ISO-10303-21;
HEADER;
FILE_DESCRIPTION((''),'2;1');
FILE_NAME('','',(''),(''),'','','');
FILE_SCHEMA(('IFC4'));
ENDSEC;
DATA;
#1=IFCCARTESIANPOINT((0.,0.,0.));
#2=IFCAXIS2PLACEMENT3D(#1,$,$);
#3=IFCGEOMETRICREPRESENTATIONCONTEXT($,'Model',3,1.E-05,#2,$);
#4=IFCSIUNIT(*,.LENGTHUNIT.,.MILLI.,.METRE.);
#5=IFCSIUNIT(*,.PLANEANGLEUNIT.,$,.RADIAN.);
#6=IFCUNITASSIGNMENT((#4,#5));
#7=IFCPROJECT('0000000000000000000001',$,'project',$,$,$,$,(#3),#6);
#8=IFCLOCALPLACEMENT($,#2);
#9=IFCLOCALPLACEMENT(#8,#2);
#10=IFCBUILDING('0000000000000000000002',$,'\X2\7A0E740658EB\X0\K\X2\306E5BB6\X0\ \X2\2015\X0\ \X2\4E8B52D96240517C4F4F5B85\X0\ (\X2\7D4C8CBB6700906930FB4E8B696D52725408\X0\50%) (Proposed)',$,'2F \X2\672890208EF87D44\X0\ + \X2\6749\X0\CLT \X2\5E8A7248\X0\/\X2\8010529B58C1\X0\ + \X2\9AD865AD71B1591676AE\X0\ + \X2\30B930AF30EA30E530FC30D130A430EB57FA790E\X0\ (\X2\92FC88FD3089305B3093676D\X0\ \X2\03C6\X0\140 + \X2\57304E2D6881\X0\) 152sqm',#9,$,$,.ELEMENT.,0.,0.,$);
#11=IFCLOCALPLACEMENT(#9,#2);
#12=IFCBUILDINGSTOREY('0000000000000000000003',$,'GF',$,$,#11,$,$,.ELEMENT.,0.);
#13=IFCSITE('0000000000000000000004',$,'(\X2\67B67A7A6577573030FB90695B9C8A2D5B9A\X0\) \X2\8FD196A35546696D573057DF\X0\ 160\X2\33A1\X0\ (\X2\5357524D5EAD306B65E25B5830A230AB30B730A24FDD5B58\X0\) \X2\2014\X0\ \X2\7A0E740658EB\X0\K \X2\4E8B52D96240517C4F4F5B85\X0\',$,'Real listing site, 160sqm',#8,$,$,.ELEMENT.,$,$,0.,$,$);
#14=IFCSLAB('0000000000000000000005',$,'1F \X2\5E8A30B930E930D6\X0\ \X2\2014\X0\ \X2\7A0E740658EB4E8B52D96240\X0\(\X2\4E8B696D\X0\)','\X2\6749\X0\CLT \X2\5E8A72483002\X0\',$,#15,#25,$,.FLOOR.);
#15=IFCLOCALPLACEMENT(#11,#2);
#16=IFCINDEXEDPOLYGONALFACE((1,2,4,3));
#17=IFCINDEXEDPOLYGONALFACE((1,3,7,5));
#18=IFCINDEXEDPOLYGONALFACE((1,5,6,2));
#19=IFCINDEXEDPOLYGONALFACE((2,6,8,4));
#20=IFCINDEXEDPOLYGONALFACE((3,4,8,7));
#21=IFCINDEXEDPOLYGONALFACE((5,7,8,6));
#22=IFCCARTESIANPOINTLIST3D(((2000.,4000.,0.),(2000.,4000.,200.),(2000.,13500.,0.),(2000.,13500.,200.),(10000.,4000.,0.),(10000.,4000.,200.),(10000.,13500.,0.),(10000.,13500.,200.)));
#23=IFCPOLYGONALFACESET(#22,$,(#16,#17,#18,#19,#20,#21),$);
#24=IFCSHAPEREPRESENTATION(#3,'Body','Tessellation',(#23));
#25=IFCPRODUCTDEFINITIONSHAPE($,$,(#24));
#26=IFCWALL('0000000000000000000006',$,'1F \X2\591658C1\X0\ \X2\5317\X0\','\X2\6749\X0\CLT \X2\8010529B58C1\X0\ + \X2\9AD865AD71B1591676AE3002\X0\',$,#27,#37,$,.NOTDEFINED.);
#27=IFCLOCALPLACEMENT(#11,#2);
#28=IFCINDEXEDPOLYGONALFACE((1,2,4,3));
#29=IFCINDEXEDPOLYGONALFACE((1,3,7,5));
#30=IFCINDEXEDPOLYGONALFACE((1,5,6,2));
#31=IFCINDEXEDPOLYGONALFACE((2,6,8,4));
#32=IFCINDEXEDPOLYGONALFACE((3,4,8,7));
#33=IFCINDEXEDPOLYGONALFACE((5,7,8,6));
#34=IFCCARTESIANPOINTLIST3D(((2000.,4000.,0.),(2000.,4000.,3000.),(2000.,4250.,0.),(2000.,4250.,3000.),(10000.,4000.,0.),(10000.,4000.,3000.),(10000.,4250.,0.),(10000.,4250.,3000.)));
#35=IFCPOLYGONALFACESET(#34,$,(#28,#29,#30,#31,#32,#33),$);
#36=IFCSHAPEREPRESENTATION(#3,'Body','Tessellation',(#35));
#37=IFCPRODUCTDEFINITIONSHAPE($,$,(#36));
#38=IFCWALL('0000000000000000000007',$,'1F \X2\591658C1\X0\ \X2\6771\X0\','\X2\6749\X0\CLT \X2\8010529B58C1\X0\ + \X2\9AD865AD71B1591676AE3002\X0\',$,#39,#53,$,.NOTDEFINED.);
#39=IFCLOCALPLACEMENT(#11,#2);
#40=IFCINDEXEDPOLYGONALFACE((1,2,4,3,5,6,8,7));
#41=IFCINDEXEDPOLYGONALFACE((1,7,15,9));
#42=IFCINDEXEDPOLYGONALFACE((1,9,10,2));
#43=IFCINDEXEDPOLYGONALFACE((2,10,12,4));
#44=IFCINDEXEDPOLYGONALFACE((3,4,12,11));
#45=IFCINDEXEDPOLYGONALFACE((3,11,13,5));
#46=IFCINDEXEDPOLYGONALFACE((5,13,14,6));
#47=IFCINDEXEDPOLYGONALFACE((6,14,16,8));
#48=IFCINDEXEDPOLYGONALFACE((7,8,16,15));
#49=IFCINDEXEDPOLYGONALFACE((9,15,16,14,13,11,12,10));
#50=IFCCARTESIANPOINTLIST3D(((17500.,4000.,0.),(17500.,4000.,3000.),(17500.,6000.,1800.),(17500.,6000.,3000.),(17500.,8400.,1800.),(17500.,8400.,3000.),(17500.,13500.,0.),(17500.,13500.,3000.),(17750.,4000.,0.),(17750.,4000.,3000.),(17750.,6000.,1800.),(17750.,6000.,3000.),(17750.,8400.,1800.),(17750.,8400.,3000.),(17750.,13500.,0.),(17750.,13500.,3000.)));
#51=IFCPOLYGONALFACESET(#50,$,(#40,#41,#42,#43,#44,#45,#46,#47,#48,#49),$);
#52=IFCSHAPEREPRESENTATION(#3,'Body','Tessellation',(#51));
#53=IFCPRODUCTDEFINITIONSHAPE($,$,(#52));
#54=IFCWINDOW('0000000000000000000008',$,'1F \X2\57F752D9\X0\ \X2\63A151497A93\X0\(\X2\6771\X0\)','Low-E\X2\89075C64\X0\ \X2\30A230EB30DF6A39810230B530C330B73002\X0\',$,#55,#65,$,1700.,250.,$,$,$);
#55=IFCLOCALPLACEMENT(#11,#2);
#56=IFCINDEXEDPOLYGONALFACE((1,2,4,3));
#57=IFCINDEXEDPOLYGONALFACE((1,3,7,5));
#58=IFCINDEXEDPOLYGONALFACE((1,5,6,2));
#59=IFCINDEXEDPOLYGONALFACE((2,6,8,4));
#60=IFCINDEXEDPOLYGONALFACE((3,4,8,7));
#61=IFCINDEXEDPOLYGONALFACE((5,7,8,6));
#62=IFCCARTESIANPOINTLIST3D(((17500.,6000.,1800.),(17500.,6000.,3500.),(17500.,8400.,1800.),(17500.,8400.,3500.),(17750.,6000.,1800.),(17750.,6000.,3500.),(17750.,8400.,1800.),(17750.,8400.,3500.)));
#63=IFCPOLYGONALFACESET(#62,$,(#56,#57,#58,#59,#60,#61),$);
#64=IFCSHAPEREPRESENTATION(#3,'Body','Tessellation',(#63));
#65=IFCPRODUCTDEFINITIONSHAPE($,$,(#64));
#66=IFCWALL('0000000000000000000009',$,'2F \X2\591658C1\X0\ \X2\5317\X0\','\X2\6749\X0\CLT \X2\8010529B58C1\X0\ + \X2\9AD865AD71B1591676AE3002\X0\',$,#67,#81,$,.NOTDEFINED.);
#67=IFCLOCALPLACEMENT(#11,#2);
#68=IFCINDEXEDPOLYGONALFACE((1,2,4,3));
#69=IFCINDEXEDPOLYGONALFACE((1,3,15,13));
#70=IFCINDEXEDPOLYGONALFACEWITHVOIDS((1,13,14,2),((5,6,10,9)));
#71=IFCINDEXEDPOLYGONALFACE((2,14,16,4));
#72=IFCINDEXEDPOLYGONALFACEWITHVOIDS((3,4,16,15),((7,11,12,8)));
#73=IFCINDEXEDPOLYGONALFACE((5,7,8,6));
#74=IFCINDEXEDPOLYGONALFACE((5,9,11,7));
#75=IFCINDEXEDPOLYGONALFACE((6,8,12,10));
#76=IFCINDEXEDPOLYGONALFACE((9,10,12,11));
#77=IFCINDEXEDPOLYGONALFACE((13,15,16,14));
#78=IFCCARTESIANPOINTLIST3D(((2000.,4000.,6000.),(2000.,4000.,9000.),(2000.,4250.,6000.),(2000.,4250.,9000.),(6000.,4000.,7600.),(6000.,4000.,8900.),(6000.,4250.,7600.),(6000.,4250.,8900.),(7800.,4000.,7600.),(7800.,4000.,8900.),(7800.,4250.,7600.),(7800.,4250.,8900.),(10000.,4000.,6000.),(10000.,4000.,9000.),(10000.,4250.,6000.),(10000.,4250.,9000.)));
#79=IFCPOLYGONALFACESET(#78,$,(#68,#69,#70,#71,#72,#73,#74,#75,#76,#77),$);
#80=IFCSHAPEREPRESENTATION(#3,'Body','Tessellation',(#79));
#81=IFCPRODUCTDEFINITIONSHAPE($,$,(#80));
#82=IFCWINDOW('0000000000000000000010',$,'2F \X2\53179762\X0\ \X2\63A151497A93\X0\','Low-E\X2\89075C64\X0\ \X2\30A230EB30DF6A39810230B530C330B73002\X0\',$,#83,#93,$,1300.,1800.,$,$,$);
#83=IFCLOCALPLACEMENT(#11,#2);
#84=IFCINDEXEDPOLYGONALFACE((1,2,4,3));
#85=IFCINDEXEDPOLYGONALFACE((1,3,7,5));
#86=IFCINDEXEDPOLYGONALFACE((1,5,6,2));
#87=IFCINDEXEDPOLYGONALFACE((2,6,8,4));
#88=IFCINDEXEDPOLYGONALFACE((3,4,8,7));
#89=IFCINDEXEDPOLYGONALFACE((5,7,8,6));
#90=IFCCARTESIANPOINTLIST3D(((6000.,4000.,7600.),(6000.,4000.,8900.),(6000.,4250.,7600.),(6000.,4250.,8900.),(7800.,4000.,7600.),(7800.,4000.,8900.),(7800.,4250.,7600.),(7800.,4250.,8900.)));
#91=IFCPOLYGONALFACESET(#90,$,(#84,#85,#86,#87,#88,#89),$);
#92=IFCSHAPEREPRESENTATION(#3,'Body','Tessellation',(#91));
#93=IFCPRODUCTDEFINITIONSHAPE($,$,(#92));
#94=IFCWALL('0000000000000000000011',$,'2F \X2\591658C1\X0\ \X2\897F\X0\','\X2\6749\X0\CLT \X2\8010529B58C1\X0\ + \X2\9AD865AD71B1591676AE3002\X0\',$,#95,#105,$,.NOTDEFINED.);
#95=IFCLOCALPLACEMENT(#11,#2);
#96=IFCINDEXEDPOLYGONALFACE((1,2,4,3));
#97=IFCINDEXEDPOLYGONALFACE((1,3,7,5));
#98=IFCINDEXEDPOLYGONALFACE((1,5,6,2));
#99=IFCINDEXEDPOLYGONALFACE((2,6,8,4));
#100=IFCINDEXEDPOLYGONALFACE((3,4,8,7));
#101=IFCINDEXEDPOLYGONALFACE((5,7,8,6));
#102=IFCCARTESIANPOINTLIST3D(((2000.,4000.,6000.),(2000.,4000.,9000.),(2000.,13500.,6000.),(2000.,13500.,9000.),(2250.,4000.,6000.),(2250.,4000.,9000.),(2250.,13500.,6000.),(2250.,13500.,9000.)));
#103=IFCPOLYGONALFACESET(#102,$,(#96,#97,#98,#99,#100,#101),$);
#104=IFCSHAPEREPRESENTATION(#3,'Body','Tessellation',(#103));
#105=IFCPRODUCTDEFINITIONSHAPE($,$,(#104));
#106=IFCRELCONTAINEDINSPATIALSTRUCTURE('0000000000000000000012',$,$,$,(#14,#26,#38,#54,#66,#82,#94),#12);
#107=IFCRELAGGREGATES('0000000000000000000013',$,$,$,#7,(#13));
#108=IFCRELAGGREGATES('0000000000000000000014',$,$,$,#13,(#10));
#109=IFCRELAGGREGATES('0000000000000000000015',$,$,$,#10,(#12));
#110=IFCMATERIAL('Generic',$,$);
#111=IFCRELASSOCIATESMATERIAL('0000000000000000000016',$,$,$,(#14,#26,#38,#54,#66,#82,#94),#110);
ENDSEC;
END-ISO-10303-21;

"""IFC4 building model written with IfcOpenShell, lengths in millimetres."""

from ifc_helpers import new_model, si_unit, frame, frame_2d, origin, place, context, project, spatial, rectangle, extrude, material, element, fill, save


model = new_model("IFC4")

# Units and contexts
model_context = context("Model", 3, precision=1e-05, world=origin())
ifc_project = project(units=[si_unit("LENGTHUNIT", "METRE", prefix="MILLI"), si_unit("PLANEANGLEUNIT", "RADIAN")], contexts=[model_context])

# Site, building, storey
site_placement = place(None, origin())
site = spatial("IfcSite", under=ifc_project, at=site_placement, Name="(架空敷地・適宜設定) 近隣商業地域 160㎡ (南前庭に既存アカシア保存) — 税理士K 事務所兼住宅", ObjectType="Real listing site, 160sqm", CompositionType="ELEMENT", RefElevation=0.0)
building_placement = place(site_placement, origin())
building = spatial("IfcBuilding", under=site, at=building_placement, Name="税理士Kの家 ― 事務所兼住宅 (経費最適・事業割合50%) (Proposed)", ObjectType="2F 木造軸組 + 杉CLT 床版/耐力壁 + 高断熱外皮 + スクリューパイル基礎 (鋼製らせん杭 φ140 + 地中梁) 152sqm", CompositionType="ELEMENT", ElevationOfRefHeight=0.0, ElevationOfTerrain=0.0)
storey_placement = place(building_placement, origin())
storey = spatial("IfcBuildingStorey", under=building, at=storey_placement, Name="GF", CompositionType="ELEMENT", Elevation=0.0)

# Shared definitions
ifc_material = material(Name="Generic")

# Slab
slab_1_placement = place(storey_placement, frame((1000.0, 2000.0, 0.0)))
element("IfcSlab", 1, at=slab_1_placement, inside=storey, material=ifc_material, Name="1F 床スラブ — 税理士事務所(事業)", Description="杉CLT 床版。", PredefinedType="FLOOR", context=model_context, shape_type="SweptSolid", body=[
    extrude(rectangle(XDim=8000.0, YDim=9500.0, at=frame_2d((4000.0, 4750.0))), frame((1000.0, 2000.0, 0.0)), (0.0, 0.0, 1.0), 200.0),
])

# Wall
wall_1_placement = place(storey_placement, frame((1000.0, 2000.0, 0.0)))
element("IfcWall", 2, at=wall_1_placement, inside=storey, material=ifc_material, Name="1F 外壁 北", Description="杉CLT 耐力壁 + 高断熱外皮。", PredefinedType="NOTDEFINED", context=model_context, shape_type="SweptSolid", body=[
    extrude(rectangle(XDim=8000.0, YDim=250.0, at=frame_2d((4000.0, 125.0))), frame((1000.0, 2000.0, 0.0)), (0.0, 0.0, 1.0), 3000.0),
])

# Wall, opening, window
wall_2_placement = place(storey_placement, frame((8750.0, 2000.0, 0.0)))
wall_2 = element("IfcWall", 3, at=wall_2_placement, inside=storey, material=ifc_material, Name="1F 外壁 東", Description="杉CLT 耐力壁 + 高断熱外皮。", PredefinedType="NOTDEFINED", context=model_context, shape_type="SweptSolid", body=[
    extrude(rectangle(XDim=250.0, YDim=9500.0, at=frame_2d((125.0, 4750.0))), frame((8750.0, 2000.0, 0.0)), (0.0, 0.0, 1.0), 3000.0),
])
opening_1_placement = place(storey_placement, frame((8750.0, 3000.0, 900.0)))
opening_1 = element("IfcOpeningElement", 4, at=opening_1_placement, cuts=wall_2, PredefinedType="NOTDEFINED", context=model_context, shape_type="SweptSolid", body=[
    extrude(rectangle(XDim=250.0, YDim=2400.0, at=frame_2d((125.0, 1200.0))), frame((8750.0, 3000.0, 900.0)), (0.0, 0.0, 1.0), 1700.0),
])
window_1_placement = place(storey_placement, frame((8750.0, 3000.0, 900.0)))
window_1 = element("IfcWindow", 5, at=window_1_placement, inside=storey, material=ifc_material, Name="1F 執務 採光窓(東)", Description="Low-E複層 アルミ樹脂サッシ。", OverallHeight=1700.0, OverallWidth=250.0, context=model_context, shape_type="SweptSolid", body=[
    extrude(rectangle(XDim=250.0, YDim=2400.0, at=frame_2d((125.0, 1200.0))), frame((8750.0, 3000.0, 900.0)), (0.0, 0.0, 1.0), 1700.0),
])
fill(opening_1, window_1)

# Wall, opening, window
wall_3_placement = place(storey_placement, frame((1000.0, 2000.0, 3000.0)))
wall_3 = element("IfcWall", 6, at=wall_3_placement, inside=storey, material=ifc_material, Name="2F 外壁 北", Description="杉CLT 耐力壁 + 高断熱外皮。", PredefinedType="NOTDEFINED", context=model_context, shape_type="SweptSolid", body=[
    extrude(rectangle(XDim=8000.0, YDim=250.0, at=frame_2d((4000.0, 125.0))), frame((1000.0, 2000.0, 3000.0)), (0.0, 0.0, 1.0), 3000.0),
])
opening_2_placement = place(storey_placement, frame((3000.0, 2000.0, 3800.0)))
opening_2 = element("IfcOpeningElement", 7, at=opening_2_placement, cuts=wall_3, PredefinedType="NOTDEFINED", context=model_context, shape_type="SweptSolid", body=[
    extrude(rectangle(XDim=1800.0, YDim=250.0, at=frame_2d((900.0, 125.0))), frame((3000.0, 2000.0, 3800.0)), (0.0, 0.0, 1.0), 1300.0),
])
window_2_placement = place(storey_placement, frame((3000.0, 2000.0, 3800.0)))
window_2 = element("IfcWindow", 8, at=window_2_placement, inside=storey, material=ifc_material, Name="2F 北面 採光窓", Description="Low-E複層 アルミ樹脂サッシ。", OverallHeight=1300.0, OverallWidth=1800.0, context=model_context, shape_type="SweptSolid", body=[
    extrude(rectangle(XDim=1800.0, YDim=250.0, at=frame_2d((900.0, 125.0))), frame((3000.0, 2000.0, 3800.0)), (0.0, 0.0, 1.0), 1300.0),
])
fill(opening_2, window_2)

# Wall
wall_4_placement = place(storey_placement, frame((1000.0, 2000.0, 3000.0)))
element("IfcWall", 9, at=wall_4_placement, inside=storey, material=ifc_material, Name="2F 外壁 西", Description="杉CLT 耐力壁 + 高断熱外皮。", PredefinedType="NOTDEFINED", context=model_context, shape_type="SweptSolid", body=[
    extrude(rectangle(XDim=250.0, YDim=9500.0, at=frame_2d((125.0, 4750.0))), frame((1000.0, 2000.0, 3000.0)), (0.0, 0.0, 1.0), 3000.0),
])

save(model, "model.ifc")
